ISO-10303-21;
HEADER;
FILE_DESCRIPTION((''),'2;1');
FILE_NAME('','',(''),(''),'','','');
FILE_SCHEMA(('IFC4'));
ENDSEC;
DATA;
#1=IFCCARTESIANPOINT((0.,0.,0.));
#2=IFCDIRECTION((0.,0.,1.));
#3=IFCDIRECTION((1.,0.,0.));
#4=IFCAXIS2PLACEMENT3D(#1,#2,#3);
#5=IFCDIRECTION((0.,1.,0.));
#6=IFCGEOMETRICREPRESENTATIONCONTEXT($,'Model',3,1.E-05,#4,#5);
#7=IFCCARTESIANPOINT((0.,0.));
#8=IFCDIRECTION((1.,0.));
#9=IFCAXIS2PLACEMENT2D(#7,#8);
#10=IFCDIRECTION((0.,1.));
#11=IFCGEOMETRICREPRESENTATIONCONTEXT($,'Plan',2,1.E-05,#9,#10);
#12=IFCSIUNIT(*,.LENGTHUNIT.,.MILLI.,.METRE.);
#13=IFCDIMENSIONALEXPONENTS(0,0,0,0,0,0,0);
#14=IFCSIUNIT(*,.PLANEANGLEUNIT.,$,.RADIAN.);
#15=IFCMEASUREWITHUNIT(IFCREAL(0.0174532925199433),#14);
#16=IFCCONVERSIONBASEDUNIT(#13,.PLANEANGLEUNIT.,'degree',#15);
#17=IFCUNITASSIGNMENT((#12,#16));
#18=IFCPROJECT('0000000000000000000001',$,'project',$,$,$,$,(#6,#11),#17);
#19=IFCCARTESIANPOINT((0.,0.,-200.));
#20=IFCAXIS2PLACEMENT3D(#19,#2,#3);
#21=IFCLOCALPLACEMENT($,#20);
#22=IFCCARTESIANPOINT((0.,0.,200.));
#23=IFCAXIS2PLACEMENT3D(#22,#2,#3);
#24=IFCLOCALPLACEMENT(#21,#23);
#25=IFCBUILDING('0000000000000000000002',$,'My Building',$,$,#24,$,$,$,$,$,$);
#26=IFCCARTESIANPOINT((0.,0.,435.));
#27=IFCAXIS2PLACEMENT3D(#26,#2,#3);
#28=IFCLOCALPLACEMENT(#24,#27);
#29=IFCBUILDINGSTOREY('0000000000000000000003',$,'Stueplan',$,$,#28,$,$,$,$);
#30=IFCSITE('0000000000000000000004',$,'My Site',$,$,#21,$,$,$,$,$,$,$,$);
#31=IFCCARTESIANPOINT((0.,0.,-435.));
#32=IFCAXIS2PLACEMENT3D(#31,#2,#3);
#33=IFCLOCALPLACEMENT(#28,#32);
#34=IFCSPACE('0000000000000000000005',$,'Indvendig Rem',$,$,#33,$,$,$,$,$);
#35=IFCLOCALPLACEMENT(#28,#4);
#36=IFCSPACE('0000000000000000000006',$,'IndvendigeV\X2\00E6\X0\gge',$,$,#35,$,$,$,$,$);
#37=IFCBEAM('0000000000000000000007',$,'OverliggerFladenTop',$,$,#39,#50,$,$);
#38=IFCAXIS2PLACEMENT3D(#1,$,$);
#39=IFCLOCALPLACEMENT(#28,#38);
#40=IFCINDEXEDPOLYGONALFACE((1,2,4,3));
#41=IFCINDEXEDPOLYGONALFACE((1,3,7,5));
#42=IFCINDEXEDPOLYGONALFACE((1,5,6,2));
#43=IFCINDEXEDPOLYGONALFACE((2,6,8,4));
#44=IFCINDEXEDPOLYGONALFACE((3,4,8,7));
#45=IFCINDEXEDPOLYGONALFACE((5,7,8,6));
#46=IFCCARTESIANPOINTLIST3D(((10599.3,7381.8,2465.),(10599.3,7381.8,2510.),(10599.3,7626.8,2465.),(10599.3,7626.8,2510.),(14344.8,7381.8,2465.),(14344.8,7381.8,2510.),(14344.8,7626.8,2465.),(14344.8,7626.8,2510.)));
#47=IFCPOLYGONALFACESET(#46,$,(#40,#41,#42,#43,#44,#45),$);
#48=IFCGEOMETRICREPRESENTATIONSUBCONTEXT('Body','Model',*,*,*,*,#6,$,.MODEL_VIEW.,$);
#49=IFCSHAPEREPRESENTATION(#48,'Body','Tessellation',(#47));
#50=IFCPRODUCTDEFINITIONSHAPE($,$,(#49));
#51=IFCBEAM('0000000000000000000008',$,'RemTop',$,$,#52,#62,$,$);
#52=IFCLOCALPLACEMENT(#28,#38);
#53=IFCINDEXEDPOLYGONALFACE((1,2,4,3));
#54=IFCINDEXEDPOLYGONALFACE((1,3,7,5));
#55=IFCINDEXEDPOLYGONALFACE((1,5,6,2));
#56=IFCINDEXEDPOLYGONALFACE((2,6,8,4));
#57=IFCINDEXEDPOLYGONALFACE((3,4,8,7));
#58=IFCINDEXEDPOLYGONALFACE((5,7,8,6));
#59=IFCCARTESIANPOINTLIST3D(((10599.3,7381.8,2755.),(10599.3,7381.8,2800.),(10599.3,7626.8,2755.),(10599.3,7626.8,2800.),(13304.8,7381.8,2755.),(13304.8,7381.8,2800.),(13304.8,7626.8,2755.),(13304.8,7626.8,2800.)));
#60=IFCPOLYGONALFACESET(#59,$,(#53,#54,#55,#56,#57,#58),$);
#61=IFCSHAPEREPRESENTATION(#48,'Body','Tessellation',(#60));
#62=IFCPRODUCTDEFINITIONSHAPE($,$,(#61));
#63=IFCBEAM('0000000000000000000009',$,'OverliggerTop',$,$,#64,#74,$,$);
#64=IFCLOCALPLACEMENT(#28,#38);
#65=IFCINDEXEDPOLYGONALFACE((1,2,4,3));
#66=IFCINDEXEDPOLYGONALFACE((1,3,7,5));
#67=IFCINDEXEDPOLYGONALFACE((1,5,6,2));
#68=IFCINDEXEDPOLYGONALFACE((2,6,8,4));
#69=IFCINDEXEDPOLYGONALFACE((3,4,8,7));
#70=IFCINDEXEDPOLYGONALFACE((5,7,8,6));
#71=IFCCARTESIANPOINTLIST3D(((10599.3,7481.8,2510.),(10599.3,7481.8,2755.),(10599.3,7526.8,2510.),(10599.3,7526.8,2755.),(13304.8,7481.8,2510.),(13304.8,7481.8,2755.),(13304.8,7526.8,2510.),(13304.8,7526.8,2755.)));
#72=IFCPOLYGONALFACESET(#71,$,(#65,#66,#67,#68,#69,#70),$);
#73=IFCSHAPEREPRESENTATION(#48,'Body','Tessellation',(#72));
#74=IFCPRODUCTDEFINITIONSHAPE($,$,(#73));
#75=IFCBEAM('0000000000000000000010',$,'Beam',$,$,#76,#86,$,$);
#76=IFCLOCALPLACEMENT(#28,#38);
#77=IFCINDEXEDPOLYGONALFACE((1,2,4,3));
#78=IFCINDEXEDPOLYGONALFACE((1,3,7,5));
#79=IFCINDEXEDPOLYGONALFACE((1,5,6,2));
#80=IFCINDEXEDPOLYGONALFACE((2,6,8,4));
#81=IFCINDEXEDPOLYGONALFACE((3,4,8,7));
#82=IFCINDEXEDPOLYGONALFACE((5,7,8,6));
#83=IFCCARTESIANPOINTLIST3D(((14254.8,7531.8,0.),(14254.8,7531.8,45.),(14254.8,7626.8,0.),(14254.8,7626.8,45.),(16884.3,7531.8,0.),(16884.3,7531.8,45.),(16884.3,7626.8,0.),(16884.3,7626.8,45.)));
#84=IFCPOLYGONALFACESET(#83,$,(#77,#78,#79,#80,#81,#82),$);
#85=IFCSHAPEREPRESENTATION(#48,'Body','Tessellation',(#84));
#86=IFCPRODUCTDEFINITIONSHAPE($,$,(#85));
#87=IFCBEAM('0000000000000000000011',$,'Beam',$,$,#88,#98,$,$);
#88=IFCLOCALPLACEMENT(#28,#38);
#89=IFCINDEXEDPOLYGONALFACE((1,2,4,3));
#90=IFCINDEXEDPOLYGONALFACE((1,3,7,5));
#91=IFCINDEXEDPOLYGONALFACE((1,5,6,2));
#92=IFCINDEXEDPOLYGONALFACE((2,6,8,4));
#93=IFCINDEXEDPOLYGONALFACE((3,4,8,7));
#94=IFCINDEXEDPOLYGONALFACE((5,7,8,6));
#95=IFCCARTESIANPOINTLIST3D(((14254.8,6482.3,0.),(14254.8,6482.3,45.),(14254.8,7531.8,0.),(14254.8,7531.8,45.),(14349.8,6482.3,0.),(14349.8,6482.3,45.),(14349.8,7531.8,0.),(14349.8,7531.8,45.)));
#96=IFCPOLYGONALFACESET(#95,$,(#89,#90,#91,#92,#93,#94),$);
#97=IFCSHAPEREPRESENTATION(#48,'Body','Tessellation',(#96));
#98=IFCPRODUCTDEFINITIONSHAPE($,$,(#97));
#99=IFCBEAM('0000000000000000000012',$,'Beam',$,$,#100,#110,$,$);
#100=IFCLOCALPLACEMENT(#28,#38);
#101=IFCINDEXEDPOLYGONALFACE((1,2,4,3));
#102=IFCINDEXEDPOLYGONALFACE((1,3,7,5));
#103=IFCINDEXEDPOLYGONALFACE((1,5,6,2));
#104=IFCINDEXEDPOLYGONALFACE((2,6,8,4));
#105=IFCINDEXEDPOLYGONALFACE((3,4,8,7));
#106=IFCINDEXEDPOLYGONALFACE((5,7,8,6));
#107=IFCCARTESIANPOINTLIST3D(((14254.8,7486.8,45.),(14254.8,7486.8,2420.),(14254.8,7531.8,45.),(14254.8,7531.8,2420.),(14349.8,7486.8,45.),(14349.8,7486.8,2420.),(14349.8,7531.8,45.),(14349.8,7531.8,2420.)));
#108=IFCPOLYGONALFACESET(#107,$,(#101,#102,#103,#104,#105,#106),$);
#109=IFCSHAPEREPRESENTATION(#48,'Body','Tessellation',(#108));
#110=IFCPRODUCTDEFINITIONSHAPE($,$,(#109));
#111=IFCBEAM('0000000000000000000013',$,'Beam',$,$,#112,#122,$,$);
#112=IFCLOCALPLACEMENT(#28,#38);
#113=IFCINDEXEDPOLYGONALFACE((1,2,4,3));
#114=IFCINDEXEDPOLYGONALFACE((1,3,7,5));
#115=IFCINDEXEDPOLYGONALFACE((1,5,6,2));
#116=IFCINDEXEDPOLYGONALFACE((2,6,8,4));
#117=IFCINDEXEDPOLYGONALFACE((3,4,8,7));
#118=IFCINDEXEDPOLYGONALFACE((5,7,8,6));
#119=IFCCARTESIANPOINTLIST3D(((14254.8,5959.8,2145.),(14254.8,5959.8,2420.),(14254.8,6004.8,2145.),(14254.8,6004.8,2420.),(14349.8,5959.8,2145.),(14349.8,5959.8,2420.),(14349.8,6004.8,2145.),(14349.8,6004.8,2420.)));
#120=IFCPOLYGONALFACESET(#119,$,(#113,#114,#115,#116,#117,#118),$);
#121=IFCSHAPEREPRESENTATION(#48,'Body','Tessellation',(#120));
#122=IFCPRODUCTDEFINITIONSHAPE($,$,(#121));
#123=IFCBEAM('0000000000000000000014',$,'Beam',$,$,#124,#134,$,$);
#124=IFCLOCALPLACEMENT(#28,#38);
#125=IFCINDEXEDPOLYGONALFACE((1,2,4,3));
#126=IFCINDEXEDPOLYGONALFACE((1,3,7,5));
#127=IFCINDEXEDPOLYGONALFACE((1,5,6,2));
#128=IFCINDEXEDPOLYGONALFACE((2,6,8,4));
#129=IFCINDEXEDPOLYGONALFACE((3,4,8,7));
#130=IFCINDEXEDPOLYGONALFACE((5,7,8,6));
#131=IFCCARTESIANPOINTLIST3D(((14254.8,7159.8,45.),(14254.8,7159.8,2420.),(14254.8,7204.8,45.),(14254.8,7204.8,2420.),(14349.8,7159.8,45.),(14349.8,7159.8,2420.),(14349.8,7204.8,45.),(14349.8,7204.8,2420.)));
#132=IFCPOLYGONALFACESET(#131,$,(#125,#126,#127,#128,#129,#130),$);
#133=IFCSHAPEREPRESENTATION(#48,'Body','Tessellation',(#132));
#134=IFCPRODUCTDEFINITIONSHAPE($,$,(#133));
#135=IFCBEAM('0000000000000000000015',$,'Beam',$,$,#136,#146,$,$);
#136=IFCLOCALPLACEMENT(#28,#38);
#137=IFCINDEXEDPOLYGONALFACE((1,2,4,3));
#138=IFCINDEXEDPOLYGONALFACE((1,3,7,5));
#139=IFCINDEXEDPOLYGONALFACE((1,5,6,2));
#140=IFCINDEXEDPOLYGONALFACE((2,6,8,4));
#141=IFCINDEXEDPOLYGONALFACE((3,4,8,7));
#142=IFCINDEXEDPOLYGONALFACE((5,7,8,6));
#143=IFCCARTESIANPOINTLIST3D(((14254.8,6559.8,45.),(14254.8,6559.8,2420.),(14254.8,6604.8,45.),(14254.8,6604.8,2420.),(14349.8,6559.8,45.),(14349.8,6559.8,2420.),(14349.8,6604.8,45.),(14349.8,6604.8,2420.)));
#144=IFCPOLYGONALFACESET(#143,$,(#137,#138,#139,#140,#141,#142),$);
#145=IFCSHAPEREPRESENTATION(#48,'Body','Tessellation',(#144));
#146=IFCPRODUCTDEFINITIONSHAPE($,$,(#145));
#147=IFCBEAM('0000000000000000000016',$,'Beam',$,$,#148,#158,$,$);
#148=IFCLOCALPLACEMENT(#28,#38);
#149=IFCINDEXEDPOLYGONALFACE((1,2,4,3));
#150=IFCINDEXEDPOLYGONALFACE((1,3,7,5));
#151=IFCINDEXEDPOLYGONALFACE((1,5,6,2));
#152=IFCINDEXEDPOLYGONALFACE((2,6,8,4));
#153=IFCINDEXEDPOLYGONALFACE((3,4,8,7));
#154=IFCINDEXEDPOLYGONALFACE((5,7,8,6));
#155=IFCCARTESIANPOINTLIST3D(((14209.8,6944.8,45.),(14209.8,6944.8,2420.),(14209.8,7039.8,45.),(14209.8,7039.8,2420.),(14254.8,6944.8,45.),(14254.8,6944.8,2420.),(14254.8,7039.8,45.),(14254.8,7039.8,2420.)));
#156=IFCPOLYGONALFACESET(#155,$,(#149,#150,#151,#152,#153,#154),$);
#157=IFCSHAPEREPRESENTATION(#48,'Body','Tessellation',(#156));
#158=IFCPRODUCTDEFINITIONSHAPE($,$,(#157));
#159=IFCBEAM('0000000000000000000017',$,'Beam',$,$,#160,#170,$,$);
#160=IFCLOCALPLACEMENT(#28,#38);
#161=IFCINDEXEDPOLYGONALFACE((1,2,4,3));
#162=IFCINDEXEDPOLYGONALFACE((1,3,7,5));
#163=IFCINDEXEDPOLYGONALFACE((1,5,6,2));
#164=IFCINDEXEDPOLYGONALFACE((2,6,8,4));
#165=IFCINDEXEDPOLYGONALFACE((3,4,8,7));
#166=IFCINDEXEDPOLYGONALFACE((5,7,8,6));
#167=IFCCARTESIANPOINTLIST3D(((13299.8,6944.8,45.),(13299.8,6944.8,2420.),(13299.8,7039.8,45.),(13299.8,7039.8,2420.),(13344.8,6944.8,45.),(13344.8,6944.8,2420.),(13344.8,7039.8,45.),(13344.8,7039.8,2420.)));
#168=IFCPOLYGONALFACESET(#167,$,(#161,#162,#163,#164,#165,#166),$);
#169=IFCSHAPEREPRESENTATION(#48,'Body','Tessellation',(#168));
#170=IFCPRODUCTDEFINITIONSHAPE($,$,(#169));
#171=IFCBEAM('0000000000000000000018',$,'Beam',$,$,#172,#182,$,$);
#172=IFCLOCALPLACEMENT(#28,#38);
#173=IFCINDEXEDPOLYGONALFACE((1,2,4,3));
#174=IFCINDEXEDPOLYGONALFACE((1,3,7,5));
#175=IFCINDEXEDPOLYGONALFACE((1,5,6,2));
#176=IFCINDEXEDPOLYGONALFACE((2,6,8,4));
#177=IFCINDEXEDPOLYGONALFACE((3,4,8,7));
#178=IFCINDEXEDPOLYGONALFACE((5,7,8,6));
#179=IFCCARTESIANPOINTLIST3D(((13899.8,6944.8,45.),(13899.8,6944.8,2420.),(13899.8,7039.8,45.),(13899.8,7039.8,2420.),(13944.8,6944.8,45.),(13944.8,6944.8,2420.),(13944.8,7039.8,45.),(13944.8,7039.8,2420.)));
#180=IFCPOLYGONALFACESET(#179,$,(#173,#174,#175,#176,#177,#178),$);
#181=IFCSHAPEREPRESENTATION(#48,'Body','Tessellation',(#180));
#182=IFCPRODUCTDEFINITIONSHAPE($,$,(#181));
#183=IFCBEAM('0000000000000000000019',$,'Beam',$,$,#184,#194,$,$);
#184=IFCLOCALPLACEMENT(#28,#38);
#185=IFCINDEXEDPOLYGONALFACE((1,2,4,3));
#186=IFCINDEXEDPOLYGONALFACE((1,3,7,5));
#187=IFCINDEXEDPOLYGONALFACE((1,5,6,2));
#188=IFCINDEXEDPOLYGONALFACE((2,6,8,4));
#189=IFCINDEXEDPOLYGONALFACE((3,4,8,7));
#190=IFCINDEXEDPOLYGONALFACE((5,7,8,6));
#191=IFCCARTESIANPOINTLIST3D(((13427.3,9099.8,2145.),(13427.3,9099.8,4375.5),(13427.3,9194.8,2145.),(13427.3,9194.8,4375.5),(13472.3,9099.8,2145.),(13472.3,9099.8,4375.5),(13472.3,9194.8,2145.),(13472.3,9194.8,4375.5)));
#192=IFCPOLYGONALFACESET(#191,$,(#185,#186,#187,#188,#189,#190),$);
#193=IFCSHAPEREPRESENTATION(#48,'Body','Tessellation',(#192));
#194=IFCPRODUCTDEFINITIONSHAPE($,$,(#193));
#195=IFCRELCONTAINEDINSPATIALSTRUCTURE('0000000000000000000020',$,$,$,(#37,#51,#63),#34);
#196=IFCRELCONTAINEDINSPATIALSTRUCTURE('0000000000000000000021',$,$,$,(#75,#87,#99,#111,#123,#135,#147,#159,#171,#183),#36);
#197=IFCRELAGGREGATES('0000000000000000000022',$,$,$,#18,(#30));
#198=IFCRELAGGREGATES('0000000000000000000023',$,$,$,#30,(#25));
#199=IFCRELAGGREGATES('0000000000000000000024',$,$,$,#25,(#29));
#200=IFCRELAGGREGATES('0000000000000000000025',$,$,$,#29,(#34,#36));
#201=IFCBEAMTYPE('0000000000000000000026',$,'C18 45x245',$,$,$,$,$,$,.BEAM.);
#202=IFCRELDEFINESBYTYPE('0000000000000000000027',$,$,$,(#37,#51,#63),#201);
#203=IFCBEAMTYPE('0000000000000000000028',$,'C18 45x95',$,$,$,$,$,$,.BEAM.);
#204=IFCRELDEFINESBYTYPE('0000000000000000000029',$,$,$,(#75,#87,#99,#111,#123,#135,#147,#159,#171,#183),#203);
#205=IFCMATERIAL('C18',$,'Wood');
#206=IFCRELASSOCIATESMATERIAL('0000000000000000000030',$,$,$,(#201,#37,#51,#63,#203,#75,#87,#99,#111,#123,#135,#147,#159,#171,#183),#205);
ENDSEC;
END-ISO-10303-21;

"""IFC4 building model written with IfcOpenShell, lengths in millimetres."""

from ifc_helpers import new_model, entity, si_unit, converted_unit, direction, frame, origin_with_axes, origin_2d_with_axis, place, context, subcontext, project, spatial, rectangle, extrude, material, material_profile, profile_set, profile_usage, type_object, element, save


model = new_model("IFC4")

# Units and contexts
model_context = context("Model", 3, precision=1e-05, world=origin_with_axes(), true_north=direction((0.0, 1.0, 0.0)))
plan_context = context("Plan", 2, precision=1e-05, world=origin_2d_with_axis(), true_north=direction((0.0, 1.0)))
body_context_1 = subcontext(model_context, "Body", "Model", "MODEL_VIEW")
ifc_project = project(units=[si_unit("LENGTHUNIT", "METRE", prefix="MILLI"), converted_unit("PLANEANGLEUNIT", "degree", entity("IfcReal", 0.0174532925199433), si_unit("PLANEANGLEUNIT", "RADIAN"), dimensions=[0, 0, 0, 0, 0, 0, 0])], contexts=[model_context, plan_context])

# Site, building, storey, space
site_placement = place(None, frame((0.0, 0.0, -200.0), z_axis=(0.0, 0.0, 1.0), x_axis=(1.0, 0.0, 0.0)))
site = spatial("IfcSite", under=ifc_project, at=site_placement, Name="My Site")
building_placement = place(site_placement, frame((0.0, 0.0, 200.0), z_axis=(0.0, 0.0, 1.0), x_axis=(1.0, 0.0, 0.0)))
building = spatial("IfcBuilding", under=site, at=building_placement, Name="My Building")
storey_placement = place(building_placement, frame((0.0, 0.0, 435.0), z_axis=(0.0, 0.0, 1.0), x_axis=(1.0, 0.0, 0.0)))
storey = spatial("IfcBuildingStorey", under=building, at=storey_placement, Name="Stueplan")
space_1_placement = place(storey_placement, frame((0.0, 0.0, -435.0), z_axis=(0.0, 0.0, 1.0), x_axis=(1.0, 0.0, 0.0)))
space_1 = spatial("IfcSpace", under=storey, at=space_1_placement, Name="Indvendig Rem")

# Beams
ifc_material = material(Name="C18", Category="Wood")
ifc_material_profile_1 = material_profile(ifc_material, rectangle(XDim=45.0, YDim=245.0), Name="concrete")
ifc_profile_set_1 = profile_set([ifc_material_profile_1], Name="woodStructural")
ifc_profile_usage_1 = profile_usage(ifc_profile_set_1)
beam_type_1 = type_object("IfcBeamType", Name="C18 45x245", PredefinedType="BEAM", material=ifc_profile_set_1)
beam_1_placement = place(space_1_placement, frame((14344.8, 7504.3, 2922.5), z_axis=(-1.0, 0.0, 0.0), x_axis=(0.0, 0.0, 1.0)))
element("IfcBeam", 1, at=beam_1_placement, inside=space_1, type_object=beam_type_1, material=ifc_profile_usage_1, Name="OverliggerFladenTop", context=body_context_1, shape_type="SweptSolid", body=[
    extrude(rectangle(XDim=45.0, YDim=245.0), origin_with_axes(), (0.0, 0.0, 1.0), 3745.5),
])
ifc_profile_usage_2 = profile_usage(ifc_profile_set_1)
beam_2_placement = place(space_1_placement, frame((13304.8, 7504.3, 3212.5), z_axis=(-1.0, 0.0, 0.0), x_axis=(0.0, 0.0, 1.0)))
element("IfcBeam", 2, at=beam_2_placement, inside=space_1, type_object=beam_type_1, material=ifc_profile_usage_2, Name="RemTop", context=body_context_1, shape_type="SweptSolid", body=[
    extrude(rectangle(XDim=45.0, YDim=245.0), origin_with_axes(), (0.0, 0.0, 1.0), 2705.5),
])
ifc_profile_usage_3 = profile_usage(ifc_profile_set_1)
beam_3_placement = place(space_1_placement, frame((13304.8, 7504.3, 3067.5), z_axis=(-1.0, 0.0, 0.0), x_axis=(0.0, 1.0, 0.0)))
element("IfcBeam", 3, at=beam_3_placement, inside=space_1, type_object=beam_type_1, material=ifc_profile_usage_3, Name="OverliggerTop", context=body_context_1, shape_type="SweptSolid", body=[
    extrude(rectangle(XDim=45.0, YDim=245.0), origin_with_axes(), (0.0, 0.0, 1.0), 2705.5),
])

# Shared definitions
space_2_placement = place(storey_placement, frame((0.0, 0.0, 0.0), z_axis=(0.0, 0.0, 1.0), x_axis=(1.0, 0.0, 0.0)))
space_2 = spatial("IfcSpace", under=storey, at=space_2_placement, Name="IndvendigeVægge")

# Beams
ifc_material_profile_2 = material_profile(ifc_material, rectangle(XDim=45.0, YDim=95.0))
ifc_profile_set_2 = profile_set([ifc_material_profile_2], Name="woodStructural")
ifc_profile_usage_4 = profile_usage(ifc_profile_set_2, cardinal=5)
beam_type_2 = type_object("IfcBeamType", Name="C18 45x95", PredefinedType="BEAM", material=ifc_profile_set_2)
beam_4_placement = place(space_2_placement, frame((14254.8, 7579.3, 22.5), z_axis=(1.0, 0.0, 0.0), x_axis=(0.0, 0.0, 1.0)))
element("IfcBeam", 4, at=beam_4_placement, inside=space_2, type_object=beam_type_2, material=ifc_profile_usage_4, Name="Beam", context=body_context_1, shape_type="SweptSolid", body=[
    extrude(rectangle(XDim=45.0, YDim=95.0), origin_with_axes(), (0.0, 0.0, 1.0), 2629.5),
])
ifc_profile_usage_5 = profile_usage(ifc_profile_set_2, cardinal=5)
beam_5_placement = place(space_2_placement, frame((14302.3, 6482.3, 22.5), z_axis=(0.0, 1.0, 0.0), x_axis=(0.0, 0.0, 1.0)))
element("IfcBeam", 5, at=beam_5_placement, inside=space_2, type_object=beam_type_2, material=ifc_profile_usage_5, Name="Beam", context=body_context_1, shape_type="SweptSolid", body=[
    extrude(rectangle(XDim=45.0, YDim=95.0), origin_with_axes(), (0.0, 0.0, 1.0), 1049.5),
])
ifc_profile_usage_6 = profile_usage(ifc_profile_set_2)
beam_6_placement = place(space_2_placement, frame((14302.3, 7509.3, 45.0), z_axis=(0.0, 0.0, 1.0), x_axis=(0.0, -1.0, 0.0)))
element("IfcBeam", 6, at=beam_6_placement, inside=space_2, type_object=beam_type_2, material=ifc_profile_usage_6, Name="Beam", context=body_context_1, shape_type="SweptSolid", body=[
    extrude(rectangle(XDim=45.0, YDim=95.0), origin_with_axes(), (0.0, 0.0, 1.0), 2375.0),
])
ifc_profile_usage_7 = profile_usage(ifc_profile_set_2)
beam_7_placement = place(space_2_placement, frame((14302.3, 5982.3, 2145.0), z_axis=(0.0, 0.0, 1.0), x_axis=(0.0, -1.0, 0.0)))
element("IfcBeam", 7, at=beam_7_placement, inside=space_2, type_object=beam_type_2, material=ifc_profile_usage_7, Name="Beam", context=body_context_1, shape_type="SweptSolid", body=[
    extrude(rectangle(XDim=45.0, YDim=95.0), origin_with_axes(), (0.0, 0.0, 1.0), 275.0),
])
ifc_profile_usage_8 = profile_usage(ifc_profile_set_2)
beam_8_placement = place(space_2_placement, frame((14302.3, 7182.3, 45.0), z_axis=(0.0, 0.0, 1.0), x_axis=(0.0, -1.0, 0.0)))
element("IfcBeam", 8, at=beam_8_placement, inside=space_2, type_object=beam_type_2, material=ifc_profile_usage_8, Name="Beam", context=body_context_1, shape_type="SweptSolid", body=[
    extrude(rectangle(XDim=45.0, YDim=95.0), origin_with_axes(), (0.0, 0.0, 1.0), 2375.0),
])
ifc_profile_usage_9 = profile_usage(ifc_profile_set_2)
beam_9_placement = place(space_2_placement, frame((14302.3, 6582.3, 45.0), z_axis=(0.0, 0.0, 1.0), x_axis=(0.0, -1.0, 0.0)))
element("IfcBeam", 9, at=beam_9_placement, inside=space_2, type_object=beam_type_2, material=ifc_profile_usage_9, Name="Beam", context=body_context_1, shape_type="SweptSolid", body=[
    extrude(rectangle(XDim=45.0, YDim=95.0), origin_with_axes(), (0.0, 0.0, 1.0), 2375.0),
])
ifc_profile_usage_10 = profile_usage(ifc_profile_set_2)
beam_10_placement = place(space_2_placement, frame((14232.3, 6992.3, 45.0), z_axis=(0.0, 0.0, 1.0), x_axis=(-1.0, 0.0, 0.0)))
element("IfcBeam", 10, at=beam_10_placement, inside=space_2, type_object=beam_type_2, material=ifc_profile_usage_10, Name="Beam", context=body_context_1, shape_type="SweptSolid", body=[
    extrude(rectangle(XDim=45.0, YDim=95.0), origin_with_axes(), (0.0, 0.0, 1.0), 2375.0),
])
ifc_profile_usage_11 = profile_usage(ifc_profile_set_2)
beam_11_placement = place(space_2_placement, frame((13322.3, 6992.3, 45.0), z_axis=(0.0, 0.0, 1.0), x_axis=(-1.0, 0.0, 0.0)))
element("IfcBeam", 11, at=beam_11_placement, inside=space_2, type_object=beam_type_2, material=ifc_profile_usage_11, Name="Beam", context=body_context_1, shape_type="SweptSolid", body=[
    extrude(rectangle(XDim=45.0, YDim=95.0), origin_with_axes(), (0.0, 0.0, 1.0), 2375.0),
])
ifc_profile_usage_12 = profile_usage(ifc_profile_set_2)
beam_12_placement = place(space_2_placement, frame((13922.3, 6992.3, 45.0), z_axis=(0.0, 0.0, 1.0), x_axis=(-1.0, 0.0, 0.0)))
element("IfcBeam", 12, at=beam_12_placement, inside=space_2, type_object=beam_type_2, material=ifc_profile_usage_12, Name="Beam", context=body_context_1, shape_type="SweptSolid", body=[
    extrude(rectangle(XDim=45.0, YDim=95.0), origin_with_axes(), (0.0, 0.0, 1.0), 2375.0),
])
ifc_profile_usage_13 = profile_usage(ifc_profile_set_2)
beam_13_placement = place(space_2_placement, frame((13449.8, 9147.3, 2145.0), z_axis=(0.0, 0.0, 1.0), x_axis=(-1.0, 0.0, 0.0)))
element("IfcBeam", 13, at=beam_13_placement, inside=space_2, type_object=beam_type_2, material=ifc_profile_usage_13, Name="Beam", context=body_context_1, shape_type="SweptSolid", body=[
    extrude(rectangle(XDim=45.0, YDim=95.0), origin_with_axes(), (0.0, 0.0, 1.0), 2230.5),
])

save(model, "model.ifc")
